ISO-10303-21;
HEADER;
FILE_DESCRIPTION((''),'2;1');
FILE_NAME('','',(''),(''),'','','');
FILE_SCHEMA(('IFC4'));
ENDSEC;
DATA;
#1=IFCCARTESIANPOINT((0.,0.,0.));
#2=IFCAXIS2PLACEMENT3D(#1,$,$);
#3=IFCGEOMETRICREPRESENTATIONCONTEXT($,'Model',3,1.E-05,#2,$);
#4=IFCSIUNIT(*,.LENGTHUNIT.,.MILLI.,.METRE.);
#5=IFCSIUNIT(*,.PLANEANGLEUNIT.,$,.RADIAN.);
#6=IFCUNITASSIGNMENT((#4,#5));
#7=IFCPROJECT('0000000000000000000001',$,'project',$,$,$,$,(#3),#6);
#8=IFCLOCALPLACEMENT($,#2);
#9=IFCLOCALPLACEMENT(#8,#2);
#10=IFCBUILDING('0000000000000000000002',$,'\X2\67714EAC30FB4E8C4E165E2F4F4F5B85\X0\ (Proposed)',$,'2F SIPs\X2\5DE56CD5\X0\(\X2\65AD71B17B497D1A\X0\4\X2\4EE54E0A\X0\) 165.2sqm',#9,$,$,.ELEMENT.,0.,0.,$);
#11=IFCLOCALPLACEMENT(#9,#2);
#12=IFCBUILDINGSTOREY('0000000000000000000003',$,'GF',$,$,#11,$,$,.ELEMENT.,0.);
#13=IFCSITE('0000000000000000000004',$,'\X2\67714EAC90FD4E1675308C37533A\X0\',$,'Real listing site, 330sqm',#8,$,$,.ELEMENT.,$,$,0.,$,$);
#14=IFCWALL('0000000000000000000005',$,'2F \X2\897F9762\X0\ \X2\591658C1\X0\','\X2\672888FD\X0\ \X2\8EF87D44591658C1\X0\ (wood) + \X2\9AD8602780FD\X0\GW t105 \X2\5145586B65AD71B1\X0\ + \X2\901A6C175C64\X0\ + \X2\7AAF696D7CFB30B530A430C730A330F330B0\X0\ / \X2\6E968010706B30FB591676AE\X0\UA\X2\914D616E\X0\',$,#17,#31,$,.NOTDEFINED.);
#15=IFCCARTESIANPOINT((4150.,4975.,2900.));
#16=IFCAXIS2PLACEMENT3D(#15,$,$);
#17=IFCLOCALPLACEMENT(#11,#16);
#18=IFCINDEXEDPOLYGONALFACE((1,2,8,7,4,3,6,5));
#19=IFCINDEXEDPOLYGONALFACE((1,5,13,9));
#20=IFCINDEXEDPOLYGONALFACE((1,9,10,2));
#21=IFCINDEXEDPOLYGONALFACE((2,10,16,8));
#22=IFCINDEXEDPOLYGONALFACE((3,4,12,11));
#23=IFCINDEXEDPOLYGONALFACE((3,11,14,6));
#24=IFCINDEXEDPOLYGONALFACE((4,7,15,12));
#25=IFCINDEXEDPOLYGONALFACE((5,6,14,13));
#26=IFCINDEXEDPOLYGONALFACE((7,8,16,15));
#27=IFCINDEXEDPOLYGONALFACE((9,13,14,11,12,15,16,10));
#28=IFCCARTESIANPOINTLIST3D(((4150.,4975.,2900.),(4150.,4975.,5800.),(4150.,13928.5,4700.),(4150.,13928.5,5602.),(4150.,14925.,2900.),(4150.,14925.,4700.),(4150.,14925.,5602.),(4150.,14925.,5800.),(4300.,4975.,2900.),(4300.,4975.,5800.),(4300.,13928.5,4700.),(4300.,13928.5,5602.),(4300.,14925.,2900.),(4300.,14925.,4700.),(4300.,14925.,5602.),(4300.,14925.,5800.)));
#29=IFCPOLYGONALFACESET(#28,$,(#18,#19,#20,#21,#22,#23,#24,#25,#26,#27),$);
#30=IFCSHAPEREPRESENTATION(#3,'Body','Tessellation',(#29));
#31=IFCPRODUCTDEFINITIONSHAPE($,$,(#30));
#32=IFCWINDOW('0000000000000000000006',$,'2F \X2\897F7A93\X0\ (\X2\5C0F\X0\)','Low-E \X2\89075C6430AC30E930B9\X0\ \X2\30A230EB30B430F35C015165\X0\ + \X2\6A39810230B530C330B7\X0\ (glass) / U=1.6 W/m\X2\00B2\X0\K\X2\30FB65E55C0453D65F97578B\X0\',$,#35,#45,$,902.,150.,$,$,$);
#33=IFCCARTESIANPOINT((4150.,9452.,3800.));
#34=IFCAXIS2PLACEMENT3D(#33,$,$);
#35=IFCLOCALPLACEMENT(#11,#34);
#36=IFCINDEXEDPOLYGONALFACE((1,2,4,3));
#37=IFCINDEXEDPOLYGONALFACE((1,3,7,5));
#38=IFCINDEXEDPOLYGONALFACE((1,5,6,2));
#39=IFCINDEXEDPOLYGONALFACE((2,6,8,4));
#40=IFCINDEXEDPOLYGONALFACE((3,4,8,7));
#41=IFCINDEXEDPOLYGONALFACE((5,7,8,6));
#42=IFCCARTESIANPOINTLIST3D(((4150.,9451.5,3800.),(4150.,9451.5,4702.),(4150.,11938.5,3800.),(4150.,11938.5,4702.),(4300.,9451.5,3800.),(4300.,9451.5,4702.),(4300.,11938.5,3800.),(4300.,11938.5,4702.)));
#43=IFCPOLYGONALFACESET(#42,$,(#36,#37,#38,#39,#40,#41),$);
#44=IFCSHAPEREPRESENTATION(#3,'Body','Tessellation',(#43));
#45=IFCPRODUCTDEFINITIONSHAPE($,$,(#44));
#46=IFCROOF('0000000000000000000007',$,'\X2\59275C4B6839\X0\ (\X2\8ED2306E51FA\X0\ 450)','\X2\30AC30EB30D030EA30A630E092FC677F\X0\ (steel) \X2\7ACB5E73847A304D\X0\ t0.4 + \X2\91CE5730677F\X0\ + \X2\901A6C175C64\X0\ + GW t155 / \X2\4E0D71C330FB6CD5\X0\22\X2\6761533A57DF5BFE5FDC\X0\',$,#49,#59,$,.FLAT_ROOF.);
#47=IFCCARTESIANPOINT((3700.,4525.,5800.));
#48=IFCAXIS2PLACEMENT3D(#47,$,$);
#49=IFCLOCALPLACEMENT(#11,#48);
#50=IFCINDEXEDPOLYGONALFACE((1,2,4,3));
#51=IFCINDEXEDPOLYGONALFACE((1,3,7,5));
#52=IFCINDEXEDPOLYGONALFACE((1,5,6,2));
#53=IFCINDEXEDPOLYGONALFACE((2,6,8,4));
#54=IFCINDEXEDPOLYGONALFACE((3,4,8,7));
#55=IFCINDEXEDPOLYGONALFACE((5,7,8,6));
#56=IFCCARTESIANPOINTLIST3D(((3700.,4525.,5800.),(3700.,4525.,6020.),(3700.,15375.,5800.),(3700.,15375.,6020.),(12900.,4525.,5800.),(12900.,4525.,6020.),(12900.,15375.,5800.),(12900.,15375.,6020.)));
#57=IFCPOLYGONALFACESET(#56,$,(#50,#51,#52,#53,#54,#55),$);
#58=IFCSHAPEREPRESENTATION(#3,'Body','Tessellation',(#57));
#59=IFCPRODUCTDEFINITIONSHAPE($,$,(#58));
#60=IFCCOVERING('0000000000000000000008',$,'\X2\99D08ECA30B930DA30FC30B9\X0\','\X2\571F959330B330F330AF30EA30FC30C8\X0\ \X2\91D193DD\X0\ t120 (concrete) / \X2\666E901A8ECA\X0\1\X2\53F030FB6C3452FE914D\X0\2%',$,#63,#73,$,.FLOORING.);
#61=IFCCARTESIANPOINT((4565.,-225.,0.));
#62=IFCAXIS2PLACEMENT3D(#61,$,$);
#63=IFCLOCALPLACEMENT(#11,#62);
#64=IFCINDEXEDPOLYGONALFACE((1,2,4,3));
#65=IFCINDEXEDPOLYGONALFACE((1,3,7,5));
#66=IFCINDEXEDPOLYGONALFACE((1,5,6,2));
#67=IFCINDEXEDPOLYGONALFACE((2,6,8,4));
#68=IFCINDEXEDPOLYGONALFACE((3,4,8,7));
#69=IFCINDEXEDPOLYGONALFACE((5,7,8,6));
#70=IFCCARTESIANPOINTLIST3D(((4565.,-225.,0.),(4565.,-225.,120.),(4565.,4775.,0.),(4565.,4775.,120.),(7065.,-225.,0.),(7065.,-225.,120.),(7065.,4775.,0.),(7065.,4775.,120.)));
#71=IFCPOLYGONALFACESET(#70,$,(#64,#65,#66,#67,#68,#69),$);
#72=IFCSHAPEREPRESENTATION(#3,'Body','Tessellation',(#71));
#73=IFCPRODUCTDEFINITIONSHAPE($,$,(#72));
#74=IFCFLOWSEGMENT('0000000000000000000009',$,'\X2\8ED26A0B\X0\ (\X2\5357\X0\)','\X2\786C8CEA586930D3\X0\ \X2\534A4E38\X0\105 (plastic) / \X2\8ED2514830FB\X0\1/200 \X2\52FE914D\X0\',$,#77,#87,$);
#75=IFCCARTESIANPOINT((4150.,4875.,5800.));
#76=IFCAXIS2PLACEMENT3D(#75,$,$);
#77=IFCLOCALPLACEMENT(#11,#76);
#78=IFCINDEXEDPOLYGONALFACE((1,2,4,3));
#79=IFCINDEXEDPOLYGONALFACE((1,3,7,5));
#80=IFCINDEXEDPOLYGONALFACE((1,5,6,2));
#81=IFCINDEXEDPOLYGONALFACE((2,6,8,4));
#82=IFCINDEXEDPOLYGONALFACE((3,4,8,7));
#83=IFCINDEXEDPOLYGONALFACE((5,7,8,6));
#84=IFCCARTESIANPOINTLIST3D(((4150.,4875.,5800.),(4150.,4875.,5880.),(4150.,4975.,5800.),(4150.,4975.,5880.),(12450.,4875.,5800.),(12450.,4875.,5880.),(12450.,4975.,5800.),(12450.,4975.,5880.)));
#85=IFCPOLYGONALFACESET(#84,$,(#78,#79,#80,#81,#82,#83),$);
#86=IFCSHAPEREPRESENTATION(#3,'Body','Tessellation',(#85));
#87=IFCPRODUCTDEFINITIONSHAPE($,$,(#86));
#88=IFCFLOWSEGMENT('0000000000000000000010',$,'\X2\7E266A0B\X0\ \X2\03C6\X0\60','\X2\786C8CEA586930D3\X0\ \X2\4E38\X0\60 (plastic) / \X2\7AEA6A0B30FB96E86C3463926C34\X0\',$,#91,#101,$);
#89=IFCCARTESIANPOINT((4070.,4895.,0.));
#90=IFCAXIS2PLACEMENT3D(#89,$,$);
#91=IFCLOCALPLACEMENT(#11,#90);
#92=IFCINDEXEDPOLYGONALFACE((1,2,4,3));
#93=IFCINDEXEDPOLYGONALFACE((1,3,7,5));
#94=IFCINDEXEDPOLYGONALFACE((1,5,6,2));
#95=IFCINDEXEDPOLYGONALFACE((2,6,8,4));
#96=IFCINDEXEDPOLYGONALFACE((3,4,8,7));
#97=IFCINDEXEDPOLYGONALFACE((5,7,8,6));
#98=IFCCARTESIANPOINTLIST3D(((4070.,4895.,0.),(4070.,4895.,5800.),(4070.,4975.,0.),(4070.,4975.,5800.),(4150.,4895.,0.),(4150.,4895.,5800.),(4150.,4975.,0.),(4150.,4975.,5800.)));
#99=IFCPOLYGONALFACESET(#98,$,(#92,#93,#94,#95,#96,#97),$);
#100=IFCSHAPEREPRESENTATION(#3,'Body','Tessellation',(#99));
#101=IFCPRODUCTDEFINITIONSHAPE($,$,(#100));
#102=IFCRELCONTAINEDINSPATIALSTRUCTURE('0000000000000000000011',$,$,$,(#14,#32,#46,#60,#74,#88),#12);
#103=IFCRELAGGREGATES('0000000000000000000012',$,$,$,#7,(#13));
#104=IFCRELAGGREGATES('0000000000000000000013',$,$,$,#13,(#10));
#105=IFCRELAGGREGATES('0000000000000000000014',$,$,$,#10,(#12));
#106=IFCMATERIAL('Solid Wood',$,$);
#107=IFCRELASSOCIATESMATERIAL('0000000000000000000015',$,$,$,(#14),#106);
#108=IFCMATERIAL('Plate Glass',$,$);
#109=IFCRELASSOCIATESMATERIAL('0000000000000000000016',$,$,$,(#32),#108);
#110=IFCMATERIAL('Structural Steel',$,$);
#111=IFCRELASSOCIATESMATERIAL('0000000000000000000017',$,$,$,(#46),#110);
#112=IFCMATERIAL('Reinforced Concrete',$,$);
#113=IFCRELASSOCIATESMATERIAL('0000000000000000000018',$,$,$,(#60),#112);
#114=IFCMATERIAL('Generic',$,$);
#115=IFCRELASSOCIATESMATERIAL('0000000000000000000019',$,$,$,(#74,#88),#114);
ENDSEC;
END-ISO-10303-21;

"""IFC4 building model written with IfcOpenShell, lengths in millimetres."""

from ifc_helpers import new_model, si_unit, frame, frame_2d, origin, place, context, project, spatial, rectangle, extrude, material, element, fill, save


model = new_model("IFC4")

# Units and contexts
model_context = context("Model", 3, precision=1e-05, world=origin())
ifc_project = project(units=[si_unit("LENGTHUNIT", "METRE", prefix="MILLI"), si_unit("PLANEANGLEUNIT", "RADIAN")], contexts=[model_context])

# Site, building, storey
site_placement = place(None, origin())
site = spatial("IfcSite", under=ifc_project, at=site_placement, Name="東京都世田谷区", ObjectType="Real listing site, 330sqm", CompositionType="ELEMENT", RefElevation=0.0)
building_placement = place(site_placement, origin())
building = spatial("IfcBuilding", under=site, at=building_placement, Name="東京・二世帯住宅 (Proposed)", ObjectType="2F SIPs工法(断熱等級4以上) 165.2sqm", CompositionType="ELEMENT", ElevationOfRefHeight=0.0, ElevationOfTerrain=0.0)
storey_placement = place(building_placement, origin())
storey = spatial("IfcBuildingStorey", under=building, at=storey_placement, Name="GF", CompositionType="ELEMENT", Elevation=0.0)

# Shared definitions
ifc_material_1 = material(Name="Solid Wood")

# Shared definitions
ifc_material_2 = material(Name="Reinforced Concrete")

# Shared definitions
ifc_material_3 = material(Name="Plate Glass")

# Wall, opening, window
wall_1_placement = place(storey_placement, frame((4150.0, 4975.0, 2900.0)))
wall_1 = element("IfcWall", 1, at=wall_1_placement, inside=storey, material=ifc_material_1, Name="2F 西面 外壁", Description="木製 軸組外壁 (wood) + 高性能GW t105 充填断熱 + 通気層 + 窯業系サイディング / 準耐火・外皮UA配慮", PredefinedType="NOTDEFINED", context=model_context, shape_type="SweptSolid", body=[
    extrude(rectangle(XDim=150.0, YDim=9950.0, at=frame_2d((75.0, 4975.0))), frame((4150.0, 4975.0, 2900.0)), (0.0, 0.0, 1.0), 2900.0),
])
opening_1_placement = place(storey_placement, frame((4150.0, 9452.0, 3800.0)))
opening_1 = element("IfcOpeningElement", 2, at=opening_1_placement, cuts=wall_1, PredefinedType="NOTDEFINED", context=model_context, shape_type="SweptSolid", body=[
    extrude(rectangle(XDim=150.0, YDim=2487.0, at=frame_2d((75.0, 1243.0))), frame((4150.0, 9452.0, 3800.0)), (0.0, 0.0, 1.0), 902.0),
])
window_1_placement = place(storey_placement, frame((4150.0, 9452.0, 3800.0)))
window_1 = element("IfcWindow", 3, at=window_1_placement, inside=storey, material=ifc_material_3, Name="2F 西窓 (小)", Description="Low-E 複層ガラス アルゴン封入 + 樹脂サッシ (glass) / U=1.6 W/m²K・日射取得型", OverallHeight=902.0, OverallWidth=150.0, context=model_context, shape_type="SweptSolid", body=[
    extrude(rectangle(XDim=150.0, YDim=2487.0, at=frame_2d((75.0, 1243.0))), frame((4150.0, 9452.0, 3800.0)), (0.0, 0.0, 1.0), 902.0),
])
fill(opening_1, window_1)

# Roof
ifc_material_4 = material(Name="Structural Steel")
roof_placement = place(storey_placement, frame((3700.0, 4525.0, 5800.0)))
element("IfcRoof", 4, at=roof_placement, inside=storey, material=ifc_material_4, Name="大屋根 (軒の出 450)", Description="ガルバリウム鋼板 (steel) 立平葺き t0.4 + 野地板 + 通気層 + GW t155 / 不燃・法22条区域対応", PredefinedType="FLAT_ROOF", context=model_context, shape_type="SweptSolid", body=[
    extrude(rectangle(XDim=9200.0, YDim=10850.0, at=frame_2d((4600.0, 5425.0))), frame((3700.0, 4525.0, 5800.0)), (0.0, 0.0, 1.0), 220.0),
])

# Covering
covering_placement = place(storey_placement, frame((4565.0, -225.0, 0.0)))
element("IfcCovering", 5, at=covering_placement, inside=storey, material=ifc_material_2, Name="駐車スペース", Description="土間コンクリート 金鏝 t120 (concrete) / 普通車1台・水勾配2%", PredefinedType="FLOORING", context=model_context, shape_type="SweptSolid", body=[
    extrude(rectangle(XDim=2500.0, YDim=5000.0, at=frame_2d((1250.0, 2500.0))), frame((4565.0, -225.0, 0.0)), (0.0, 0.0, 1.0), 120.0),
])

# Flow segments
ifc_material_5 = material(Name="Generic")
flow_segment_1_placement = place(storey_placement, frame((4150.0, 4875.0, 5800.0)))
element("IfcFlowSegment", 6, at=flow_segment_1_placement, inside=storey, material=ifc_material_5, Name="軒樋 (南)", Description="硬質塩ビ 半丸105 (plastic) / 軒先・1/200 勾配", context=model_context, shape_type="SweptSolid", body=[
    extrude(rectangle(XDim=8300.0, YDim=100.0, at=frame_2d((4150.0, 50.0))), frame((4150.0, 4875.0, 5800.0)), (0.0, 0.0, 1.0), 80.0),
])
flow_segment_2_placement = place(storey_placement, frame((4070.0, 4895.0, 0.0)))
element("IfcFlowSegment", 7, at=flow_segment_2_placement, inside=storey, material=ifc_material_5, Name="縦樋 φ60", Description="硬質塩ビ 丸60 (plastic) / 竪樋・雨水排水", context=model_context, shape_type="SweptSolid", body=[
    extrude(rectangle(XDim=80.0, YDim=80.0, at=frame_2d((40.0, 40.0))), frame((4070.0, 4895.0, 0.0)), (0.0, 0.0, 1.0), 5800.0),
])

save(model, "model.ifc")
